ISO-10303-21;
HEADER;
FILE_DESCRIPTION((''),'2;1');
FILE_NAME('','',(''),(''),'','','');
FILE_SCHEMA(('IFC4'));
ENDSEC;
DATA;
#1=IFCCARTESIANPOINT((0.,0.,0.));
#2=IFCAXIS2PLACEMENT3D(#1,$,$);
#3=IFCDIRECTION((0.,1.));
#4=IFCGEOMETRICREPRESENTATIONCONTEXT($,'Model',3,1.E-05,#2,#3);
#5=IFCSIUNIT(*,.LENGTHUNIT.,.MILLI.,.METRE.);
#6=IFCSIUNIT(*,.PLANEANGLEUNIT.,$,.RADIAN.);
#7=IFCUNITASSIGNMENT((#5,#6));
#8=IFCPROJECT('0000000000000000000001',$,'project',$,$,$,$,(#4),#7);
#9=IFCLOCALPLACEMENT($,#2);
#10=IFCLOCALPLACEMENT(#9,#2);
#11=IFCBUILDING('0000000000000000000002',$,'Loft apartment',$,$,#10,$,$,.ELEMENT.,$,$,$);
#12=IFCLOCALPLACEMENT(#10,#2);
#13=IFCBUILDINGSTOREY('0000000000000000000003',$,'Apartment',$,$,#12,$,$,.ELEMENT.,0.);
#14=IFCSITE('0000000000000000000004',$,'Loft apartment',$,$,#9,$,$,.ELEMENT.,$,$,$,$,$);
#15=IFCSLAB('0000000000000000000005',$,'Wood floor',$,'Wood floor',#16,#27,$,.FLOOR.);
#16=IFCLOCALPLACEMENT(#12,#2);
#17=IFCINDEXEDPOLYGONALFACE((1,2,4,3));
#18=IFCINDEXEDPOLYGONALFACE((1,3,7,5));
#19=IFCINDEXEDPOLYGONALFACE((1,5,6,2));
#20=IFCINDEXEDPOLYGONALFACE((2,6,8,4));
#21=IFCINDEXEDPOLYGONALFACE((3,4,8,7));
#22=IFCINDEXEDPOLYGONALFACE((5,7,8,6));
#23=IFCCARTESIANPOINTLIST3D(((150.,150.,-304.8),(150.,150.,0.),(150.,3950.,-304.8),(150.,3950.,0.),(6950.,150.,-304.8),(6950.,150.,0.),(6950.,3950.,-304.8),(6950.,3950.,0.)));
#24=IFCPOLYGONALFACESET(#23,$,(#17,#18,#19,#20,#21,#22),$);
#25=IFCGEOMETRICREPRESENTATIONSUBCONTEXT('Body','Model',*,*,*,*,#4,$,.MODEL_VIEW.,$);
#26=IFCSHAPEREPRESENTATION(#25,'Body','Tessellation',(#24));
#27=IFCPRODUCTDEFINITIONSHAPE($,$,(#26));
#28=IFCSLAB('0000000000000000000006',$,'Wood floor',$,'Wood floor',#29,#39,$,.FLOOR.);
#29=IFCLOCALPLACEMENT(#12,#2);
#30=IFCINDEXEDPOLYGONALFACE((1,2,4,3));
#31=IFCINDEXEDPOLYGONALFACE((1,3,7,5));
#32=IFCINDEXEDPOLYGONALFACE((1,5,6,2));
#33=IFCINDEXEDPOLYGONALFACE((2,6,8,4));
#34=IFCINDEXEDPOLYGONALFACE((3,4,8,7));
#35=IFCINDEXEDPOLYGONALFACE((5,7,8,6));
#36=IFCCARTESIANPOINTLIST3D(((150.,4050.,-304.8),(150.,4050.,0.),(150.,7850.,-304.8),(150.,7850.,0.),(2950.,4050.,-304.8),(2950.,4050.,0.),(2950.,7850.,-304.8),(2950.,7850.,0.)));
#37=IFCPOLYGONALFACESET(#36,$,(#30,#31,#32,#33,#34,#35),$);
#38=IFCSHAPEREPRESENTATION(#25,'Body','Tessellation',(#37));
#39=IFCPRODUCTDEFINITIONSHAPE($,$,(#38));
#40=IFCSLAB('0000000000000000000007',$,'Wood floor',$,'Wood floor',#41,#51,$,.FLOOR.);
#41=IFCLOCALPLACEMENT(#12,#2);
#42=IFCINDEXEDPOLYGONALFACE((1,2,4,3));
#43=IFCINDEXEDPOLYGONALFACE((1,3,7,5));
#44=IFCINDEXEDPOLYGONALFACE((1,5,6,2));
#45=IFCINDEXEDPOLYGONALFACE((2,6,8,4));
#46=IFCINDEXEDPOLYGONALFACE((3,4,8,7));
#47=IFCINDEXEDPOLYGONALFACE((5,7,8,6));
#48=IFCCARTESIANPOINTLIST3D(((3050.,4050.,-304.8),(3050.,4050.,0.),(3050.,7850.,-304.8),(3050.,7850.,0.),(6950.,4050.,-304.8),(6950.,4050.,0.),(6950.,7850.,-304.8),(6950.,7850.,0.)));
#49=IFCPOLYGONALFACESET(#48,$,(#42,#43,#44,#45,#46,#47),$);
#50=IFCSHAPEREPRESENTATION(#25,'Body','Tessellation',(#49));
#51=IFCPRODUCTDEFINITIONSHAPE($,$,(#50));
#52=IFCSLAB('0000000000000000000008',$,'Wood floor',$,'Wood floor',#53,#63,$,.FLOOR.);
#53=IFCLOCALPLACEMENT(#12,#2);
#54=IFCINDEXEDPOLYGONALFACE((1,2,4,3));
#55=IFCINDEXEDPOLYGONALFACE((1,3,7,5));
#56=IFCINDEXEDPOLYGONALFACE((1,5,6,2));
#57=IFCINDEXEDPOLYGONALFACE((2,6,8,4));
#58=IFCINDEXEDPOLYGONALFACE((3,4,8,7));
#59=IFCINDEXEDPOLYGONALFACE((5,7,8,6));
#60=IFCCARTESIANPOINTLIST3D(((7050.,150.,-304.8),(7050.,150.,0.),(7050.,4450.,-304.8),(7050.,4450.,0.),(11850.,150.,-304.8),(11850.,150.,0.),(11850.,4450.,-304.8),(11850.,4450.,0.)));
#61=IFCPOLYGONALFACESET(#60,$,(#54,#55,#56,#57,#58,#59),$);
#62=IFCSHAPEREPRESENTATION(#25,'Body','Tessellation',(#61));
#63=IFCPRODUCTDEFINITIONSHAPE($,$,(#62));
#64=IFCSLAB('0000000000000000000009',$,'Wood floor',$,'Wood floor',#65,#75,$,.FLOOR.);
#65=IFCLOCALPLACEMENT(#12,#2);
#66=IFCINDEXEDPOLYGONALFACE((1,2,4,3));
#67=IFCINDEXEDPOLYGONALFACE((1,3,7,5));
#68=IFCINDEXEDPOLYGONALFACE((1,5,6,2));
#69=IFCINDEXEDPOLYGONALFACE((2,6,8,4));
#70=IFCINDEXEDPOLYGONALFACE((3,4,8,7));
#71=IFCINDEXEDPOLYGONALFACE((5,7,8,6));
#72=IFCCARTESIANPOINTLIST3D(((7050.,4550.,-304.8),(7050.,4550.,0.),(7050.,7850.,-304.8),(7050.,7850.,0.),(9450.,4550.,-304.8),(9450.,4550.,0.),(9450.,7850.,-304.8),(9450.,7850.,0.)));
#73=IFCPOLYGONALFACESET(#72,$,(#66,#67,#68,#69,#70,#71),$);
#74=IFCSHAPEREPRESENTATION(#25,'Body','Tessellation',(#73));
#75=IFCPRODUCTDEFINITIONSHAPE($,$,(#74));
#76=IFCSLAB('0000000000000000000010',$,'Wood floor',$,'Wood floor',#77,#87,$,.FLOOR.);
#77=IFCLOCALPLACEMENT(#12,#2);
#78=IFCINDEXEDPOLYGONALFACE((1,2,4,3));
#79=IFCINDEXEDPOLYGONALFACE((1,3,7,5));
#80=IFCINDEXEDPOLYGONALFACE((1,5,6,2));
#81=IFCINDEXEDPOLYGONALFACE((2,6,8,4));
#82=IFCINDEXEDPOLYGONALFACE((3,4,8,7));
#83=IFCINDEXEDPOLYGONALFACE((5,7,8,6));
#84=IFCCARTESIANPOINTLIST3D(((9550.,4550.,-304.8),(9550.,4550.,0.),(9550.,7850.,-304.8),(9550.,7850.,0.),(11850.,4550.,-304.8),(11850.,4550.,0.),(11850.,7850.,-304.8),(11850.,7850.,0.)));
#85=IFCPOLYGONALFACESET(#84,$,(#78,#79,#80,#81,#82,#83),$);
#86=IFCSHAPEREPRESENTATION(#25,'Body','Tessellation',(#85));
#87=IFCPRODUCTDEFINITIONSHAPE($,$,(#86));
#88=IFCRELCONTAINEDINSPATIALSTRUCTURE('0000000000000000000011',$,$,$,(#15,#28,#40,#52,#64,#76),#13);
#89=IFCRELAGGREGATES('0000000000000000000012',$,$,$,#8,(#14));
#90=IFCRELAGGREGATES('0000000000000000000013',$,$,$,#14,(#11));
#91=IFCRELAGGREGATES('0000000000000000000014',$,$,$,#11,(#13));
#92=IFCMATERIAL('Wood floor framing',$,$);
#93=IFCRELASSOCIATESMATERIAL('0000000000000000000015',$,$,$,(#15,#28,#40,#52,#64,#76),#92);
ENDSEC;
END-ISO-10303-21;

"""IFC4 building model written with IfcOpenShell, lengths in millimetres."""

from ifc_helpers import new_model, si_unit, direction, frame, origin, origin_with_axes, place, context, subcontext, project, spatial, polyline, outline, extrude, material, element, save


model = new_model("IFC4")

# Units and contexts
model_context = context("Model", 3, precision=1e-05, world=origin(), true_north=direction((0.0, 1.0)))
body_context = subcontext(model_context, "Body", "Model", "MODEL_VIEW")
ifc_project = project(units=[si_unit("LENGTHUNIT", "METRE", prefix="MILLI"), si_unit("PLANEANGLEUNIT", "RADIAN")], contexts=[model_context])

# Site, building, storey
site_placement = place(None, origin())
site = spatial("IfcSite", under=ifc_project, at=site_placement, Name="Loft apartment", CompositionType="ELEMENT")
building_placement = place(site_placement, origin())
building = spatial("IfcBuilding", under=site, at=building_placement, Name="Loft apartment", CompositionType="ELEMENT")
storey_placement = place(building_placement, origin())
storey = spatial("IfcBuildingStorey", under=building, at=storey_placement, Name="Apartment", CompositionType="ELEMENT", Elevation=0.0)

# Slabs
ifc_material_1 = material(Name="Wood floor framing")
slab_1_placement = place(storey_placement, origin_with_axes())
element("IfcSlab", 1, at=slab_1_placement, inside=storey, material=ifc_material_1, Name="Wood floor", ObjectType="Wood floor", PredefinedType="FLOOR", context=body_context, shape_type="SweptSolid", body=[
    extrude(outline(polyline([(150.0, 150.0), (6950.0, 150.0), (6950.0, 3950.0), (150.0, 3950.0), (150.0, 150.0)])), frame((0.0, 0.0, -304.8)), (0.0, 0.0, 1.0), 304.8),
])
slab_2_placement = place(storey_placement, origin_with_axes())
element("IfcSlab", 2, at=slab_2_placement, inside=storey, material=ifc_material_1, Name="Wood floor", ObjectType="Wood floor", PredefinedType="FLOOR", context=body_context, shape_type="SweptSolid", body=[
    extrude(outline(polyline([(2950.0, 7850.0), (150.0, 7850.0), (150.0, 4050.0), (2950.0, 4050.0), (2950.0, 7850.0)])), frame((0.0, 0.0, -304.8)), (0.0, 0.0, 1.0), 304.8),
])
slab_3_placement = place(storey_placement, origin_with_axes())
element("IfcSlab", 3, at=slab_3_placement, inside=storey, material=ifc_material_1, Name="Wood floor", ObjectType="Wood floor", PredefinedType="FLOOR", context=body_context, shape_type="SweptSolid", body=[
    extrude(outline(polyline([(6950.0, 7850.0), (3050.0, 7850.0), (3050.0, 4050.0), (6950.0, 4050.0), (6950.0, 7850.0)])), frame((0.0, 0.0, -304.8)), (0.0, 0.0, 1.0), 304.8),
])
slab_4_placement = place(storey_placement, origin_with_axes())
element("IfcSlab", 4, at=slab_4_placement, inside=storey, material=ifc_material_1, Name="Wood floor", ObjectType="Wood floor", PredefinedType="FLOOR", context=body_context, shape_type="SweptSolid", body=[
    extrude(outline(polyline([(7050.0, 150.0), (11850.0, 150.0), (11850.0, 4450.0), (7050.0, 4450.0), (7050.0, 150.0)])), frame((0.0, 0.0, -304.8)), (0.0, 0.0, 1.0), 304.8),
])
slab_5_placement = place(storey_placement, origin_with_axes())
element("IfcSlab", 5, at=slab_5_placement, inside=storey, material=ifc_material_1, Name="Wood floor", ObjectType="Wood floor", PredefinedType="FLOOR", context=body_context, shape_type="SweptSolid", body=[
    extrude(outline(polyline([(9450.0, 7850.0), (7050.0, 7850.0), (7050.0, 4550.0), (9450.0, 4550.0), (9450.0, 7850.0)])), frame((0.0, 0.0, -304.8)), (0.0, 0.0, 1.0), 304.8),
])
slab_6_placement = place(storey_placement, origin_with_axes())
element("IfcSlab", 6, at=slab_6_placement, inside=storey, material=ifc_material_1, Name="Wood floor", ObjectType="Wood floor", PredefinedType="FLOOR", context=body_context, shape_type="SweptSolid", body=[
    extrude(outline(polyline([(11850.0, 4550.0), (11850.0, 7850.0), (9550.0, 7850.0), (9550.0, 4550.0), (11850.0, 4550.0)])), frame((0.0, 0.0, -304.8)), (0.0, 0.0, 1.0), 304.8),
])

save(model, "model.ifc")
